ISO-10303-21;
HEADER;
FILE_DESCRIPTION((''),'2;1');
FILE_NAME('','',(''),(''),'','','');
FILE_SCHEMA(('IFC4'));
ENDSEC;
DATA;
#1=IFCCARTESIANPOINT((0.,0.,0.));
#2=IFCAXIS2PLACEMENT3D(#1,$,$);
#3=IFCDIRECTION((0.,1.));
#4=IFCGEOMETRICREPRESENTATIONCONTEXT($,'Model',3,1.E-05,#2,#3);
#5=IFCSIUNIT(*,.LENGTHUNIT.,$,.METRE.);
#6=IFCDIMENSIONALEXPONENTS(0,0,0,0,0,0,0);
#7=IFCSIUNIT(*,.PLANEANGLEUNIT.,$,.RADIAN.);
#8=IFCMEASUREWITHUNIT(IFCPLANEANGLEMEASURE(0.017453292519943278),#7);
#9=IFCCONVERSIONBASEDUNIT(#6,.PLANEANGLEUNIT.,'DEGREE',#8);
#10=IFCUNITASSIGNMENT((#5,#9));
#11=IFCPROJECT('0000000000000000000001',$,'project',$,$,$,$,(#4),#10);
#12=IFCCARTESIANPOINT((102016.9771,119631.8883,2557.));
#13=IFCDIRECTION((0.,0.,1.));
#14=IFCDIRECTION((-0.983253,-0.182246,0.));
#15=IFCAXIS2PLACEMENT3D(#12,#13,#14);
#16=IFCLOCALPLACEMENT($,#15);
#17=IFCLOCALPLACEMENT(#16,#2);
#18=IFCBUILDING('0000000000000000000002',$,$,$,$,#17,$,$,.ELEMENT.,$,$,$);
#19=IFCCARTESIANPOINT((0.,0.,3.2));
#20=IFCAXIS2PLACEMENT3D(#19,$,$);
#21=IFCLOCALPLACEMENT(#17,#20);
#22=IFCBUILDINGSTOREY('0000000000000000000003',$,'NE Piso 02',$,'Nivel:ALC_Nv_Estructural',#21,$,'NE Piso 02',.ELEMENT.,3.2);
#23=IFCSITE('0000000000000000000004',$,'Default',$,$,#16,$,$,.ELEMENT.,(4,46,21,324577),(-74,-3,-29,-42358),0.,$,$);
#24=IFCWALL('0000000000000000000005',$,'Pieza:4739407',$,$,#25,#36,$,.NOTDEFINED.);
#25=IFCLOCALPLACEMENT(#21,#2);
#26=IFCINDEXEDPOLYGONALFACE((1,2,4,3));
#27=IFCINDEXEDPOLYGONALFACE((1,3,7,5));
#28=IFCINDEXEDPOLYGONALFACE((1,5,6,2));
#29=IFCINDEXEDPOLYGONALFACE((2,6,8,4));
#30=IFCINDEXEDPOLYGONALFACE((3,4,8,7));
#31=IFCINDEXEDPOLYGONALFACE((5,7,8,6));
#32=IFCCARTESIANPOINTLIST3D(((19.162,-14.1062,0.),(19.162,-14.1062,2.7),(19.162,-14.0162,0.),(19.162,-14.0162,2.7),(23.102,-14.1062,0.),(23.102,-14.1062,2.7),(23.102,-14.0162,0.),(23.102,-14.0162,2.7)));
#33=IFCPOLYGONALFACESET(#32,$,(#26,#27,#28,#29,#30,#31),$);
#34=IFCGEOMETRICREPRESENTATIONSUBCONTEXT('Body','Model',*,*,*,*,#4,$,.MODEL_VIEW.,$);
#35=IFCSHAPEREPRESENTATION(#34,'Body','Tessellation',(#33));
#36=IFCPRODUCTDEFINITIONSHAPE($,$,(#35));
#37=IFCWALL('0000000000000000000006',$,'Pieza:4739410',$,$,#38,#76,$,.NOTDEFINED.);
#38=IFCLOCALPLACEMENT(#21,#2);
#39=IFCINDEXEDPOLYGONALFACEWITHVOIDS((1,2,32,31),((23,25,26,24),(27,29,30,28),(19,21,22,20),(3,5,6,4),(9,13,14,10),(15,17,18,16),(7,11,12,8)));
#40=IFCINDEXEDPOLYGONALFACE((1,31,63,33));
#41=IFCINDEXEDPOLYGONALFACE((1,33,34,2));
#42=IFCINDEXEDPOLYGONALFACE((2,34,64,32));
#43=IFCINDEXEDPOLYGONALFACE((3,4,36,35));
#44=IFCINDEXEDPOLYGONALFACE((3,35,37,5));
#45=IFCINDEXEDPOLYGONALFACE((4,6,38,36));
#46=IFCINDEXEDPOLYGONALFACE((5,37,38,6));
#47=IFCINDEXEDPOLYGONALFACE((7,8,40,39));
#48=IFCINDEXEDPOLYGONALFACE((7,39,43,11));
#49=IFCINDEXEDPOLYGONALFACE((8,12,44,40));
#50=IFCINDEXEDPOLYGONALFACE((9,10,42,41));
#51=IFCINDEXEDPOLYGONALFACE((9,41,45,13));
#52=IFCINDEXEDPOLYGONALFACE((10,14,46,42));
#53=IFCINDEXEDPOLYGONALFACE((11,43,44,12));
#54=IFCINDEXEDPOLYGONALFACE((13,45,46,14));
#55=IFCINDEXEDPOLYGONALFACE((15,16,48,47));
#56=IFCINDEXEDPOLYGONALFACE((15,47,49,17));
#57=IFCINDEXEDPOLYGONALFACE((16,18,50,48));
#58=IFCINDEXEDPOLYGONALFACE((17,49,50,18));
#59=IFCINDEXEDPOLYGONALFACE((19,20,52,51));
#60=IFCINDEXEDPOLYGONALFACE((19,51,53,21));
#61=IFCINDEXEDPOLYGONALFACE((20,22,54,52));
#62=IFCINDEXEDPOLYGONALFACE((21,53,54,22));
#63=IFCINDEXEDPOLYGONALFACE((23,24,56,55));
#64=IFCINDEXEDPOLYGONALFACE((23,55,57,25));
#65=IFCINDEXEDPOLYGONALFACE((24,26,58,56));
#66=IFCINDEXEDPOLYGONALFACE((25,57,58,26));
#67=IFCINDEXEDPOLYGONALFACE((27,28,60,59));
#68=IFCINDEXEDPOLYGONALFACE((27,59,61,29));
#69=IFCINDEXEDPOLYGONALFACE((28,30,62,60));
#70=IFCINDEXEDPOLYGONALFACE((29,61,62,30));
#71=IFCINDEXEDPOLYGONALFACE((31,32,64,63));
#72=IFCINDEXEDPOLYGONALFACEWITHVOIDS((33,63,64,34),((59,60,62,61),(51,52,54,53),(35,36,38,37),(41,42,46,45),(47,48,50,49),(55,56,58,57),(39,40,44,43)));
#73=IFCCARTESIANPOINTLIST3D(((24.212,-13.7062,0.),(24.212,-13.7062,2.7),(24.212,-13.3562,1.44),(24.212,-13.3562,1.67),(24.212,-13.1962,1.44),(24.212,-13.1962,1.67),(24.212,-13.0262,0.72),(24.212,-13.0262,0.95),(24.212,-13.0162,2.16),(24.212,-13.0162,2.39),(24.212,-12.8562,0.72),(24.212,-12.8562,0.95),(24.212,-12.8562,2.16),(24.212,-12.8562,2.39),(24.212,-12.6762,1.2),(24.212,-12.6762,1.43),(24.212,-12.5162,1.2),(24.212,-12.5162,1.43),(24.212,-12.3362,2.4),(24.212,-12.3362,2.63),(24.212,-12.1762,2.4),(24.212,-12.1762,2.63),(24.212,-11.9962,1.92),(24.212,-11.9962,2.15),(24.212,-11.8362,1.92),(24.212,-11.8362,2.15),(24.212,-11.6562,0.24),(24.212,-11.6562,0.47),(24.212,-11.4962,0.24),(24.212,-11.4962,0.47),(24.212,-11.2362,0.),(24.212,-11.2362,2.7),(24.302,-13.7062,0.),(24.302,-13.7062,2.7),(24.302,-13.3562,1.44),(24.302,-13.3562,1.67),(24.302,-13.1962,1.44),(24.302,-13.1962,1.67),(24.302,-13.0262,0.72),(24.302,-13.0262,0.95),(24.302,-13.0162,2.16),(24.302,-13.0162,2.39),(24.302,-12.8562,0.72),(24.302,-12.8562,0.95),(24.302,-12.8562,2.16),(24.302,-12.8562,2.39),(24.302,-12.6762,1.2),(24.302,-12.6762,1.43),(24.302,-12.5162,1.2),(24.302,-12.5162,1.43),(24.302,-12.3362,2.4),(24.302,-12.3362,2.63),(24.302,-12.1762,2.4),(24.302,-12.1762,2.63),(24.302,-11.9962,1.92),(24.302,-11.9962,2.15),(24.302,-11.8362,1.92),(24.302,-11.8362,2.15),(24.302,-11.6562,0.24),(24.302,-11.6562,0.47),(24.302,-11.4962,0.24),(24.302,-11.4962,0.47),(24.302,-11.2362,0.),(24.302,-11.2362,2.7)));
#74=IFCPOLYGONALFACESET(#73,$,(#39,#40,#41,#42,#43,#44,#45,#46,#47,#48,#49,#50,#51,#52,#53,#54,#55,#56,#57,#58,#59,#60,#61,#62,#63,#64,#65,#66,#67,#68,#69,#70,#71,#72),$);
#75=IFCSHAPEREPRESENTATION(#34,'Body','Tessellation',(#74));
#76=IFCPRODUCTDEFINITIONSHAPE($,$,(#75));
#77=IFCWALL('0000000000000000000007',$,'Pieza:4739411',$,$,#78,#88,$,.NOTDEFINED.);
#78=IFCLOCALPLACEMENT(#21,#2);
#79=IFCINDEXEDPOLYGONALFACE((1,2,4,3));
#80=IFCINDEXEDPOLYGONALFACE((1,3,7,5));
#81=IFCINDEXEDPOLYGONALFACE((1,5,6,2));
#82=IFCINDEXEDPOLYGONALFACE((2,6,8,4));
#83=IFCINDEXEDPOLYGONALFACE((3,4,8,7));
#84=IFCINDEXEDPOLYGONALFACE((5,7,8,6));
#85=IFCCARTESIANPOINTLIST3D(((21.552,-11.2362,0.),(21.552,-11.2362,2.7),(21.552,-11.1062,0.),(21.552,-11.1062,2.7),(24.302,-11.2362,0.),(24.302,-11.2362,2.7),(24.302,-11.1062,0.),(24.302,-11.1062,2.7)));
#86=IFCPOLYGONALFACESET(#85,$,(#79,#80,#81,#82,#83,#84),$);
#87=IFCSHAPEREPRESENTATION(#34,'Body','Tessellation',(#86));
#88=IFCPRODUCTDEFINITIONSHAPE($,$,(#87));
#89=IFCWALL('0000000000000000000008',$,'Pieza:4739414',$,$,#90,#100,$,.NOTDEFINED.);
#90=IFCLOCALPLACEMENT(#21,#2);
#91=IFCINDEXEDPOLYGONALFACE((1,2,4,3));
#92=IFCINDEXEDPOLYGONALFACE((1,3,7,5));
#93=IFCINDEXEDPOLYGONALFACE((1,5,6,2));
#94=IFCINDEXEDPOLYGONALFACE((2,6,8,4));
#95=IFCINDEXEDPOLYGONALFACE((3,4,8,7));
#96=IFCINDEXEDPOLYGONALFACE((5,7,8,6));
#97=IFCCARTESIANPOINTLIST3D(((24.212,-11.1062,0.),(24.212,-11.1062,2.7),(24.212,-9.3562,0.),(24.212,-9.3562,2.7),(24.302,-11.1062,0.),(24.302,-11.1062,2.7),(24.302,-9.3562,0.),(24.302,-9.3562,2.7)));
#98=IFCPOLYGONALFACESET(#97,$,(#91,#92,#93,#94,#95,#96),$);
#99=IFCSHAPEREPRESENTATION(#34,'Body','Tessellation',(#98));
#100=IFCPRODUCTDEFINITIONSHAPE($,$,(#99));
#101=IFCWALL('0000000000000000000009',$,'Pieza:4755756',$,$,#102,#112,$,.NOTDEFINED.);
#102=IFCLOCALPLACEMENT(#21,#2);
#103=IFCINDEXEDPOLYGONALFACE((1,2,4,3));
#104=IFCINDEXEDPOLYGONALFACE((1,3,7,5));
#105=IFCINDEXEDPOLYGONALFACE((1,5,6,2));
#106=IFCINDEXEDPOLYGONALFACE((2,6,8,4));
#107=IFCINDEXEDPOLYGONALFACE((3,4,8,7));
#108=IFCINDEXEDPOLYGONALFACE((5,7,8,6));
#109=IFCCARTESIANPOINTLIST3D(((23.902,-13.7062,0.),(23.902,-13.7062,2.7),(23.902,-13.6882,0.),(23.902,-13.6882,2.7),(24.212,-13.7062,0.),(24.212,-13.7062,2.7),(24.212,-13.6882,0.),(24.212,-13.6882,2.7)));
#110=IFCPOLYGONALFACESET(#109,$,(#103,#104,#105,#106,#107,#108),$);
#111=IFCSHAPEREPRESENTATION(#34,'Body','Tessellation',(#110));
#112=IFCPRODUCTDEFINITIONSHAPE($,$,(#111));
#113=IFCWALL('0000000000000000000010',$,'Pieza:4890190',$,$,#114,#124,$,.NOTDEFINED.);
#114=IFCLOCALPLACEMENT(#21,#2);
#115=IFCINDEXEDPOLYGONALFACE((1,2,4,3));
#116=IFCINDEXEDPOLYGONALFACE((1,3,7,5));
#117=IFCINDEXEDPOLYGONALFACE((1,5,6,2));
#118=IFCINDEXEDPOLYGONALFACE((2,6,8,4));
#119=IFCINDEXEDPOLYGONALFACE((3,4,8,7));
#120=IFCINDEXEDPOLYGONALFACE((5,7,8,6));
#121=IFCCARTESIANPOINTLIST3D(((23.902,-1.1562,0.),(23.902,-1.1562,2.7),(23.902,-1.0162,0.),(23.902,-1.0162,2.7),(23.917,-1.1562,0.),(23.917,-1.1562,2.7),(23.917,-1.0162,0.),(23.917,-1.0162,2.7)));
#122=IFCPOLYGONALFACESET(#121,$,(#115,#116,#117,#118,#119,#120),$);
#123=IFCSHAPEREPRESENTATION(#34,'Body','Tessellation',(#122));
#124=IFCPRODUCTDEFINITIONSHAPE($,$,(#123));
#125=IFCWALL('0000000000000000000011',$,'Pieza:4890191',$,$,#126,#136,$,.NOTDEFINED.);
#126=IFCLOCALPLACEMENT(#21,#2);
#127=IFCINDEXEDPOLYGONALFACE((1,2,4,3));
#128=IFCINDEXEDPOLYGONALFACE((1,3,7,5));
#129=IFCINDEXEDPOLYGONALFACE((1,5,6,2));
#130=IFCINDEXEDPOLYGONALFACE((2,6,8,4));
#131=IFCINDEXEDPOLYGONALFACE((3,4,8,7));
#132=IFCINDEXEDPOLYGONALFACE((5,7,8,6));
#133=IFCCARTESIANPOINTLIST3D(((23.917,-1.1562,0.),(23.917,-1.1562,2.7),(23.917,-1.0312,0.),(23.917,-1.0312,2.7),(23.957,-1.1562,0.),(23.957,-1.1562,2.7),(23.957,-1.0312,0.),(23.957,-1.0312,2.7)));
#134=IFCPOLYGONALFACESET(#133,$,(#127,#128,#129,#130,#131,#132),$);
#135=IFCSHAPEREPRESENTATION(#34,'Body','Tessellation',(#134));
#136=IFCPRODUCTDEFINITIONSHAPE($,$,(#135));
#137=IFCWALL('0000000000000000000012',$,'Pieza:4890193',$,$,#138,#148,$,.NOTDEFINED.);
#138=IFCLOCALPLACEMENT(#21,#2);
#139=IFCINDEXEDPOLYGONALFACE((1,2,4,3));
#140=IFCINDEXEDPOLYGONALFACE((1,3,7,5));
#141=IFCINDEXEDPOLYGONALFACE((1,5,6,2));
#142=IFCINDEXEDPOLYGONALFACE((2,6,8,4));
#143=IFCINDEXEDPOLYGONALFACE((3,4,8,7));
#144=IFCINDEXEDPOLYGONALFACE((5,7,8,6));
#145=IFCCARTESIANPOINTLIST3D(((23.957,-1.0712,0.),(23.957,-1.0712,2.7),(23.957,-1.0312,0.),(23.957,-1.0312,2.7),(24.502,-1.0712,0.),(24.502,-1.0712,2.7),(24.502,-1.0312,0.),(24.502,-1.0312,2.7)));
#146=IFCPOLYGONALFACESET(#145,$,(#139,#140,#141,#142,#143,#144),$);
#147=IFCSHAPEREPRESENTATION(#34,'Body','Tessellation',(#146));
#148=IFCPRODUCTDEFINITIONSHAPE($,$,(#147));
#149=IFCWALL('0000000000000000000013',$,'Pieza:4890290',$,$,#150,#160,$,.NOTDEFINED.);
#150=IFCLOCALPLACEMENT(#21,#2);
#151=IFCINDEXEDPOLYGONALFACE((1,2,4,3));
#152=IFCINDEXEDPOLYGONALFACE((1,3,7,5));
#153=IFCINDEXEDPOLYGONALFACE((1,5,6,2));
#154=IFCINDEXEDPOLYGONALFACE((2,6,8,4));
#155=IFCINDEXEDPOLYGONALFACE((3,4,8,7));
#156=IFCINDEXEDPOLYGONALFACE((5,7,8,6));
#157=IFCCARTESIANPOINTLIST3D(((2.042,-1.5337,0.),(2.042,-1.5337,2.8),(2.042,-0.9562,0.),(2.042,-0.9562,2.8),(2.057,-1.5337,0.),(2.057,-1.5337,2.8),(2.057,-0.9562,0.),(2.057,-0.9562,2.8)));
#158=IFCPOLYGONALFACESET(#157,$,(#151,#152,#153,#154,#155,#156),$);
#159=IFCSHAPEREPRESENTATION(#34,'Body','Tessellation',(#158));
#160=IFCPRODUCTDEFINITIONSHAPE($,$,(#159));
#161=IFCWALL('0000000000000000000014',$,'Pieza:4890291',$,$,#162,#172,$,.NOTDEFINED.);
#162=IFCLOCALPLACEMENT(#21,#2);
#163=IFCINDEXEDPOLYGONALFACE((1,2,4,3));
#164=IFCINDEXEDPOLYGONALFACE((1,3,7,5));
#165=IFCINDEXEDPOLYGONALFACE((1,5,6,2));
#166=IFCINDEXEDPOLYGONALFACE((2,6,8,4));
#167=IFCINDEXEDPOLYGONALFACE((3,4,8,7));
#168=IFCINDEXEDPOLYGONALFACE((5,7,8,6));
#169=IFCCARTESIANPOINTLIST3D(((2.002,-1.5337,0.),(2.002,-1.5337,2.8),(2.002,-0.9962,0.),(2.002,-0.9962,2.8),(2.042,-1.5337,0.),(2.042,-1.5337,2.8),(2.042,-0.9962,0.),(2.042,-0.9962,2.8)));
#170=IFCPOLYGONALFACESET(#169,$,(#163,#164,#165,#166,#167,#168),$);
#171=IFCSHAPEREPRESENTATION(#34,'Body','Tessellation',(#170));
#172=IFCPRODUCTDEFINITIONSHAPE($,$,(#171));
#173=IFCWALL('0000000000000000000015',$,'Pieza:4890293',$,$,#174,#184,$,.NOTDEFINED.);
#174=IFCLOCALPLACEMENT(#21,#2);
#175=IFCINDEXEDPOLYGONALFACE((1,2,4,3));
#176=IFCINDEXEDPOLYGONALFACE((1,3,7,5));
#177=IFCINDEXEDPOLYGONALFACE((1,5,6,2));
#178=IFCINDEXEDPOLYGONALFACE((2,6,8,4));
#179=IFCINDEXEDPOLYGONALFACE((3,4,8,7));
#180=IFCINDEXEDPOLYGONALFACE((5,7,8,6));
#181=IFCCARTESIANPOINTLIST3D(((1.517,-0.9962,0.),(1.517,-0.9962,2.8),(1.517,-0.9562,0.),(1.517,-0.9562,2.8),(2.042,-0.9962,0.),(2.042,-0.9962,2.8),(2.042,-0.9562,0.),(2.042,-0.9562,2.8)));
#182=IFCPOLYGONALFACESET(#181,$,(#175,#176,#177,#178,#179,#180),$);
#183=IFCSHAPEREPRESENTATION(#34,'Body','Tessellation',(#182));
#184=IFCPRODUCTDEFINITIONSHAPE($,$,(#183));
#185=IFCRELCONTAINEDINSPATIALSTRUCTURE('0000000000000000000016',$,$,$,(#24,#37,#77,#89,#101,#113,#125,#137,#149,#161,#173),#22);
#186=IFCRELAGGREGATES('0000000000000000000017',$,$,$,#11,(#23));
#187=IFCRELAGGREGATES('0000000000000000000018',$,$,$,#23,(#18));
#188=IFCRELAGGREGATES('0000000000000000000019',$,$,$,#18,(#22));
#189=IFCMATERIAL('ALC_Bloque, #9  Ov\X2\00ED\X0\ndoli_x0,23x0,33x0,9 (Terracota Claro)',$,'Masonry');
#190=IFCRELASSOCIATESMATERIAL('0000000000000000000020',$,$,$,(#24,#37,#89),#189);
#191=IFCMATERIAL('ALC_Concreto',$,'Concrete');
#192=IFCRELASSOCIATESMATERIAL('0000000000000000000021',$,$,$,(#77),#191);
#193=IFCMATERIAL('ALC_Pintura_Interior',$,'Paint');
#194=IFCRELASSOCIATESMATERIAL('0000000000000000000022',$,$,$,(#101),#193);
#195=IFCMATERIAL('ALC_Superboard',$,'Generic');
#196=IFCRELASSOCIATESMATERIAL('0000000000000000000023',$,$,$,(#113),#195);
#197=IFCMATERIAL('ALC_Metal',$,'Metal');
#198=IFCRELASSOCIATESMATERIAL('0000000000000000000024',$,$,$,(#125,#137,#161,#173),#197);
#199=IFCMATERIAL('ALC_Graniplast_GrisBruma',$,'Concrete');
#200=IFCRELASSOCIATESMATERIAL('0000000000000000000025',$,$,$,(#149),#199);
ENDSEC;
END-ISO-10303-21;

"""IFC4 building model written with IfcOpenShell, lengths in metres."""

from ifc_helpers import new_model, entity, si_unit, converted_unit, direction, frame, frame_2d, origin, origin_2d_with_axis, place, context, subcontext, project, spatial, rectangle, extrude, boolean, material, element, save


model = new_model("IFC4")

# Units and contexts
model_context = context("Model", 3, precision=1e-05, world=origin(), true_north=direction((0.0, 1.0)))
body_context = subcontext(model_context, "Body", "Model", "MODEL_VIEW")
ifc_project = project(units=[si_unit("LENGTHUNIT", "METRE"), converted_unit("PLANEANGLEUNIT", "DEGREE", entity("IfcPlaneAngleMeasure", 0.017453292519943278), si_unit("PLANEANGLEUNIT", "RADIAN"), dimensions=[0, 0, 0, 0, 0, 0, 0])], contexts=[model_context])

# Site, building, storey
site_placement = place(None, frame((102016.9771, 119631.8883, 2557.0), z_axis=(0.0, 0.0, 1.0), x_axis=(-0.983253, -0.182246, 0.0)))
site = spatial("IfcSite", under=ifc_project, at=site_placement, Name="Default", CompositionType="ELEMENT", RefLatitude=(4, 46, 21, 324577), RefLongitude=(-74, -3, -29, -42358), RefElevation=0.0)
building_placement = place(site_placement, origin())
building = spatial("IfcBuilding", under=site, at=building_placement, CompositionType="ELEMENT")
storey_placement = place(building_placement, frame((0.0, 0.0, 3.2)))
storey = spatial("IfcBuildingStorey", under=building, at=storey_placement, Name="NE Piso 02", ObjectType="Nivel:ALC_Nv_Estructural", LongName="NE Piso 02", CompositionType="ELEMENT", Elevation=3.2)

# Walls
ifc_material_1 = material(Name="ALC_Bloque, #9  Ovíndoli_x0,23x0,33x0,9 (Terracota Claro)", Category="Masonry")
wall_1_placement = place(storey_placement, origin())
element("IfcWall", 1, at=wall_1_placement, inside=storey, material=ifc_material_1, Name="Pieza:4739407", PredefinedType="NOTDEFINED", context=body_context, shape_type="SweptSolid", body=[
    extrude(rectangle(XDim=0.09, YDim=3.94, at=frame_2d((0.0, 0.0), x_axis=(1.0, 0.0))), frame((21.132, -14.0612, 0.0), z_axis=(0.0, 0.0, 1.0), x_axis=(0.0, -1.0, 0.0)), (0.0, 0.0, 1.0), 2.7),
])
wall_2_placement = place(storey_placement, origin())
element("IfcWall", 2, at=wall_2_placement, inside=storey, material=ifc_material_1, Name="Pieza:4739410", PredefinedType="NOTDEFINED", context=body_context, shape_type="SweptSolid", body=[
    boolean("DIFFERENCE", boolean("DIFFERENCE", boolean("DIFFERENCE", boolean("DIFFERENCE", boolean("DIFFERENCE", boolean("DIFFERENCE", boolean("DIFFERENCE", extrude(rectangle(XDim=0.09, YDim=2.47, at=frame_2d((0.0, 0.0), x_axis=(1.0, 0.0))), frame((24.257, -12.4712, 0.0)), (0.0, 0.0, 1.0), 2.7), extrude(rectangle(XDim=0.23, YDim=0.16, at=frame_2d((0.0, 0.0), x_axis=(0.0, 1.0))), frame((24.302, -11.5762, 0.355), z_axis=(-1.0, 0.0, 0.0), x_axis=(0.0, 1.0, 0.0)), (0.0, 0.0, 1.0), 0.09)), extrude(rectangle(XDim=0.23, YDim=0.17, at=frame_2d((0.0, 0.0), x_axis=(0.0, 1.0))), frame((24.302, -12.9412, 0.835), z_axis=(-1.0, 0.0, 0.0), x_axis=(0.0, 1.0, 0.0)), (0.0, 0.0, 1.0), 0.09)), extrude(rectangle(XDim=0.23, YDim=0.16, at=frame_2d((0.0, 0.0), x_axis=(0.0, 1.0))), frame((24.302, -12.5962, 1.315), z_axis=(-1.0, 0.0, 0.0), x_axis=(0.0, 1.0, 0.0)), (0.0, 0.0, 1.0), 0.09)), extrude(rectangle(XDim=0.23, YDim=0.16, at=frame_2d((0.0, 0.0), x_axis=(0.0, 1.0))), frame((24.302, -13.2762, 1.555), z_axis=(-1.0, 0.0, 0.0), x_axis=(0.0, 1.0, 0.0)), (0.0, 0.0, 1.0), 0.09)), extrude(rectangle(XDim=0.23, YDim=0.16, at=frame_2d((0.0, 0.0), x_axis=(0.0, 1.0))), frame((24.302, -11.9162, 2.035), z_axis=(-1.0, 0.0, 0.0), x_axis=(0.0, 1.0, 0.0)), (0.0, 0.0, 1.0), 0.09)), extrude(rectangle(XDim=0.23, YDim=0.16, at=frame_2d((0.0, 0.0), x_axis=(0.0, 1.0))), frame((24.302, -12.9362, 2.275), z_axis=(-1.0, 0.0, 0.0), x_axis=(0.0, 1.0, 0.0)), (0.0, 0.0, 1.0), 0.09)), extrude(rectangle(XDim=0.23, YDim=0.16, at=frame_2d((0.0, 0.0), x_axis=(0.0, 1.0))), frame((24.302, -12.2562, 2.515), z_axis=(-1.0, 0.0, 0.0), x_axis=(0.0, 1.0, 0.0)), (0.0, 0.0, 1.0), 0.09)),
])
ifc_material_2 = material(Name="ALC_Concreto", Category="Concrete")
wall_3_placement = place(storey_placement, origin())
element("IfcWall", 3, at=wall_3_placement, inside=storey, material=ifc_material_2, Name="Pieza:4739411", PredefinedType="NOTDEFINED", context=body_context, shape_type="SweptSolid", body=[
    extrude(rectangle(XDim=0.13, YDim=2.75, at=frame_2d((0.0, 0.0), x_axis=(1.0, 0.0))), frame((22.927, -11.1712, 0.0), z_axis=(0.0, 0.0, 1.0), x_axis=(0.0, -1.0, 0.0)), (0.0, 0.0, 1.0), 2.7),
])
wall_4_placement = place(storey_placement, origin())
element("IfcWall", 4, at=wall_4_placement, inside=storey, material=ifc_material_1, Name="Pieza:4739414", PredefinedType="NOTDEFINED", context=body_context, shape_type="SweptSolid", body=[
    extrude(rectangle(XDim=1.75, YDim=0.09, at=frame_2d((0.0, 0.0), x_axis=(1.0, 0.0))), frame((24.257, -10.2312, 0.0), z_axis=(0.0, 0.0, 1.0), x_axis=(0.0, -1.0, 0.0)), (0.0, 0.0, 1.0), 2.7),
])
ifc_material_3 = material(Name="ALC_Pintura_Interior", Category="Paint")
wall_5_placement = place(storey_placement, origin())
element("IfcWall", 5, at=wall_5_placement, inside=storey, material=ifc_material_3, Name="Pieza:4755756", PredefinedType="NOTDEFINED", context=body_context, shape_type="SweptSolid", body=[
    extrude(rectangle(XDim=0.018, YDim=0.31, at=frame_2d((0.0, 0.0), x_axis=(1.0, 0.0))), frame((24.057, -13.6972, 0.0), z_axis=(0.0, 0.0, 1.0), x_axis=(0.0, -1.0, 0.0)), (0.0, 0.0, 1.0), 2.7),
])
ifc_material_4 = material(Name="ALC_Superboard", Category="Generic")
wall_6_placement = place(storey_placement, origin())
element("IfcWall", 6, at=wall_6_placement, inside=storey, material=ifc_material_4, Name="Pieza:4890190", PredefinedType="NOTDEFINED", context=body_context, shape_type="SweptSolid", body=[
    extrude(rectangle(XDim=0.14, YDim=0.015, at=frame_2d((0.0, 0.0), x_axis=(1.0, 0.0))), frame((23.9095, -1.0862, 0.0), z_axis=(0.0, 0.0, 1.0), x_axis=(0.0, -1.0, 0.0)), (0.0, 0.0, 1.0), 2.7),
])
ifc_material_5 = material(Name="ALC_Metal", Category="Metal")
wall_7_placement = place(storey_placement, origin())
element("IfcWall", 7, at=wall_7_placement, inside=storey, material=ifc_material_5, Name="Pieza:4890191", PredefinedType="NOTDEFINED", context=body_context, shape_type="SweptSolid", body=[
    extrude(rectangle(XDim=0.125, YDim=0.04, at=frame_2d((0.0, 0.0), x_axis=(1.0, 0.0))), frame((23.937, -1.0937, 0.0), z_axis=(0.0, 0.0, 1.0), x_axis=(0.0, -1.0, 0.0)), (0.0, 0.0, 1.0), 2.7),
])
wall_8_placement = place(storey_placement, origin())
element("IfcWall", 8, at=wall_8_placement, inside=storey, material=ifc_material_5, Name="Pieza:4890193", PredefinedType="NOTDEFINED", context=body_context, shape_type="SweptSolid", body=[
    extrude(rectangle(XDim=0.04, YDim=0.545, at=origin_2d_with_axis()), frame((24.2295, -1.0512, 0.0), z_axis=(0.0, 0.0, 1.0), x_axis=(0.0, -1.0, 0.0)), (0.0, 0.0, 1.0), 2.7),
])
ifc_material_6 = material(Name="ALC_Graniplast_GrisBruma", Category="Concrete")
wall_9_placement = place(storey_placement, origin())
element("IfcWall", 9, at=wall_9_placement, inside=storey, material=ifc_material_6, Name="Pieza:4890290", PredefinedType="NOTDEFINED", context=body_context, shape_type="SweptSolid", body=[
    extrude(rectangle(XDim=0.5775, YDim=0.015, at=frame_2d((0.0, 0.0), x_axis=(1.0, 0.0))), frame((2.0495, -1.2449, 0.0), z_axis=(0.0, 0.0, 1.0), x_axis=(0.0, -1.0, 0.0)), (0.0, 0.0, 1.0), 2.8),
])
wall_10_placement = place(storey_placement, origin())
element("IfcWall", 10, at=wall_10_placement, inside=storey, material=ifc_material_5, Name="Pieza:4890291", PredefinedType="NOTDEFINED", context=body_context, shape_type="SweptSolid", body=[
    extrude(rectangle(XDim=0.5375, YDim=0.04, at=origin_2d_with_axis()), frame((2.022, -1.2649, 0.0), z_axis=(0.0, 0.0, 1.0), x_axis=(0.0, -1.0, 0.0)), (0.0, 0.0, 1.0), 2.8),
])
wall_11_placement = place(storey_placement, origin())
element("IfcWall", 11, at=wall_11_placement, inside=storey, material=ifc_material_5, Name="Pieza:4890293", PredefinedType="NOTDEFINED", context=body_context, shape_type="SweptSolid", body=[
    extrude(rectangle(XDim=0.04, YDim=0.525, at=frame_2d((0.0, 0.0), x_axis=(1.0, 0.0))), frame((1.7795, -0.9762, 0.0), z_axis=(0.0, 0.0, 1.0), x_axis=(0.0, -1.0, 0.0)), (0.0, 0.0, 1.0), 2.8),
])

save(model, "model.ifc")
